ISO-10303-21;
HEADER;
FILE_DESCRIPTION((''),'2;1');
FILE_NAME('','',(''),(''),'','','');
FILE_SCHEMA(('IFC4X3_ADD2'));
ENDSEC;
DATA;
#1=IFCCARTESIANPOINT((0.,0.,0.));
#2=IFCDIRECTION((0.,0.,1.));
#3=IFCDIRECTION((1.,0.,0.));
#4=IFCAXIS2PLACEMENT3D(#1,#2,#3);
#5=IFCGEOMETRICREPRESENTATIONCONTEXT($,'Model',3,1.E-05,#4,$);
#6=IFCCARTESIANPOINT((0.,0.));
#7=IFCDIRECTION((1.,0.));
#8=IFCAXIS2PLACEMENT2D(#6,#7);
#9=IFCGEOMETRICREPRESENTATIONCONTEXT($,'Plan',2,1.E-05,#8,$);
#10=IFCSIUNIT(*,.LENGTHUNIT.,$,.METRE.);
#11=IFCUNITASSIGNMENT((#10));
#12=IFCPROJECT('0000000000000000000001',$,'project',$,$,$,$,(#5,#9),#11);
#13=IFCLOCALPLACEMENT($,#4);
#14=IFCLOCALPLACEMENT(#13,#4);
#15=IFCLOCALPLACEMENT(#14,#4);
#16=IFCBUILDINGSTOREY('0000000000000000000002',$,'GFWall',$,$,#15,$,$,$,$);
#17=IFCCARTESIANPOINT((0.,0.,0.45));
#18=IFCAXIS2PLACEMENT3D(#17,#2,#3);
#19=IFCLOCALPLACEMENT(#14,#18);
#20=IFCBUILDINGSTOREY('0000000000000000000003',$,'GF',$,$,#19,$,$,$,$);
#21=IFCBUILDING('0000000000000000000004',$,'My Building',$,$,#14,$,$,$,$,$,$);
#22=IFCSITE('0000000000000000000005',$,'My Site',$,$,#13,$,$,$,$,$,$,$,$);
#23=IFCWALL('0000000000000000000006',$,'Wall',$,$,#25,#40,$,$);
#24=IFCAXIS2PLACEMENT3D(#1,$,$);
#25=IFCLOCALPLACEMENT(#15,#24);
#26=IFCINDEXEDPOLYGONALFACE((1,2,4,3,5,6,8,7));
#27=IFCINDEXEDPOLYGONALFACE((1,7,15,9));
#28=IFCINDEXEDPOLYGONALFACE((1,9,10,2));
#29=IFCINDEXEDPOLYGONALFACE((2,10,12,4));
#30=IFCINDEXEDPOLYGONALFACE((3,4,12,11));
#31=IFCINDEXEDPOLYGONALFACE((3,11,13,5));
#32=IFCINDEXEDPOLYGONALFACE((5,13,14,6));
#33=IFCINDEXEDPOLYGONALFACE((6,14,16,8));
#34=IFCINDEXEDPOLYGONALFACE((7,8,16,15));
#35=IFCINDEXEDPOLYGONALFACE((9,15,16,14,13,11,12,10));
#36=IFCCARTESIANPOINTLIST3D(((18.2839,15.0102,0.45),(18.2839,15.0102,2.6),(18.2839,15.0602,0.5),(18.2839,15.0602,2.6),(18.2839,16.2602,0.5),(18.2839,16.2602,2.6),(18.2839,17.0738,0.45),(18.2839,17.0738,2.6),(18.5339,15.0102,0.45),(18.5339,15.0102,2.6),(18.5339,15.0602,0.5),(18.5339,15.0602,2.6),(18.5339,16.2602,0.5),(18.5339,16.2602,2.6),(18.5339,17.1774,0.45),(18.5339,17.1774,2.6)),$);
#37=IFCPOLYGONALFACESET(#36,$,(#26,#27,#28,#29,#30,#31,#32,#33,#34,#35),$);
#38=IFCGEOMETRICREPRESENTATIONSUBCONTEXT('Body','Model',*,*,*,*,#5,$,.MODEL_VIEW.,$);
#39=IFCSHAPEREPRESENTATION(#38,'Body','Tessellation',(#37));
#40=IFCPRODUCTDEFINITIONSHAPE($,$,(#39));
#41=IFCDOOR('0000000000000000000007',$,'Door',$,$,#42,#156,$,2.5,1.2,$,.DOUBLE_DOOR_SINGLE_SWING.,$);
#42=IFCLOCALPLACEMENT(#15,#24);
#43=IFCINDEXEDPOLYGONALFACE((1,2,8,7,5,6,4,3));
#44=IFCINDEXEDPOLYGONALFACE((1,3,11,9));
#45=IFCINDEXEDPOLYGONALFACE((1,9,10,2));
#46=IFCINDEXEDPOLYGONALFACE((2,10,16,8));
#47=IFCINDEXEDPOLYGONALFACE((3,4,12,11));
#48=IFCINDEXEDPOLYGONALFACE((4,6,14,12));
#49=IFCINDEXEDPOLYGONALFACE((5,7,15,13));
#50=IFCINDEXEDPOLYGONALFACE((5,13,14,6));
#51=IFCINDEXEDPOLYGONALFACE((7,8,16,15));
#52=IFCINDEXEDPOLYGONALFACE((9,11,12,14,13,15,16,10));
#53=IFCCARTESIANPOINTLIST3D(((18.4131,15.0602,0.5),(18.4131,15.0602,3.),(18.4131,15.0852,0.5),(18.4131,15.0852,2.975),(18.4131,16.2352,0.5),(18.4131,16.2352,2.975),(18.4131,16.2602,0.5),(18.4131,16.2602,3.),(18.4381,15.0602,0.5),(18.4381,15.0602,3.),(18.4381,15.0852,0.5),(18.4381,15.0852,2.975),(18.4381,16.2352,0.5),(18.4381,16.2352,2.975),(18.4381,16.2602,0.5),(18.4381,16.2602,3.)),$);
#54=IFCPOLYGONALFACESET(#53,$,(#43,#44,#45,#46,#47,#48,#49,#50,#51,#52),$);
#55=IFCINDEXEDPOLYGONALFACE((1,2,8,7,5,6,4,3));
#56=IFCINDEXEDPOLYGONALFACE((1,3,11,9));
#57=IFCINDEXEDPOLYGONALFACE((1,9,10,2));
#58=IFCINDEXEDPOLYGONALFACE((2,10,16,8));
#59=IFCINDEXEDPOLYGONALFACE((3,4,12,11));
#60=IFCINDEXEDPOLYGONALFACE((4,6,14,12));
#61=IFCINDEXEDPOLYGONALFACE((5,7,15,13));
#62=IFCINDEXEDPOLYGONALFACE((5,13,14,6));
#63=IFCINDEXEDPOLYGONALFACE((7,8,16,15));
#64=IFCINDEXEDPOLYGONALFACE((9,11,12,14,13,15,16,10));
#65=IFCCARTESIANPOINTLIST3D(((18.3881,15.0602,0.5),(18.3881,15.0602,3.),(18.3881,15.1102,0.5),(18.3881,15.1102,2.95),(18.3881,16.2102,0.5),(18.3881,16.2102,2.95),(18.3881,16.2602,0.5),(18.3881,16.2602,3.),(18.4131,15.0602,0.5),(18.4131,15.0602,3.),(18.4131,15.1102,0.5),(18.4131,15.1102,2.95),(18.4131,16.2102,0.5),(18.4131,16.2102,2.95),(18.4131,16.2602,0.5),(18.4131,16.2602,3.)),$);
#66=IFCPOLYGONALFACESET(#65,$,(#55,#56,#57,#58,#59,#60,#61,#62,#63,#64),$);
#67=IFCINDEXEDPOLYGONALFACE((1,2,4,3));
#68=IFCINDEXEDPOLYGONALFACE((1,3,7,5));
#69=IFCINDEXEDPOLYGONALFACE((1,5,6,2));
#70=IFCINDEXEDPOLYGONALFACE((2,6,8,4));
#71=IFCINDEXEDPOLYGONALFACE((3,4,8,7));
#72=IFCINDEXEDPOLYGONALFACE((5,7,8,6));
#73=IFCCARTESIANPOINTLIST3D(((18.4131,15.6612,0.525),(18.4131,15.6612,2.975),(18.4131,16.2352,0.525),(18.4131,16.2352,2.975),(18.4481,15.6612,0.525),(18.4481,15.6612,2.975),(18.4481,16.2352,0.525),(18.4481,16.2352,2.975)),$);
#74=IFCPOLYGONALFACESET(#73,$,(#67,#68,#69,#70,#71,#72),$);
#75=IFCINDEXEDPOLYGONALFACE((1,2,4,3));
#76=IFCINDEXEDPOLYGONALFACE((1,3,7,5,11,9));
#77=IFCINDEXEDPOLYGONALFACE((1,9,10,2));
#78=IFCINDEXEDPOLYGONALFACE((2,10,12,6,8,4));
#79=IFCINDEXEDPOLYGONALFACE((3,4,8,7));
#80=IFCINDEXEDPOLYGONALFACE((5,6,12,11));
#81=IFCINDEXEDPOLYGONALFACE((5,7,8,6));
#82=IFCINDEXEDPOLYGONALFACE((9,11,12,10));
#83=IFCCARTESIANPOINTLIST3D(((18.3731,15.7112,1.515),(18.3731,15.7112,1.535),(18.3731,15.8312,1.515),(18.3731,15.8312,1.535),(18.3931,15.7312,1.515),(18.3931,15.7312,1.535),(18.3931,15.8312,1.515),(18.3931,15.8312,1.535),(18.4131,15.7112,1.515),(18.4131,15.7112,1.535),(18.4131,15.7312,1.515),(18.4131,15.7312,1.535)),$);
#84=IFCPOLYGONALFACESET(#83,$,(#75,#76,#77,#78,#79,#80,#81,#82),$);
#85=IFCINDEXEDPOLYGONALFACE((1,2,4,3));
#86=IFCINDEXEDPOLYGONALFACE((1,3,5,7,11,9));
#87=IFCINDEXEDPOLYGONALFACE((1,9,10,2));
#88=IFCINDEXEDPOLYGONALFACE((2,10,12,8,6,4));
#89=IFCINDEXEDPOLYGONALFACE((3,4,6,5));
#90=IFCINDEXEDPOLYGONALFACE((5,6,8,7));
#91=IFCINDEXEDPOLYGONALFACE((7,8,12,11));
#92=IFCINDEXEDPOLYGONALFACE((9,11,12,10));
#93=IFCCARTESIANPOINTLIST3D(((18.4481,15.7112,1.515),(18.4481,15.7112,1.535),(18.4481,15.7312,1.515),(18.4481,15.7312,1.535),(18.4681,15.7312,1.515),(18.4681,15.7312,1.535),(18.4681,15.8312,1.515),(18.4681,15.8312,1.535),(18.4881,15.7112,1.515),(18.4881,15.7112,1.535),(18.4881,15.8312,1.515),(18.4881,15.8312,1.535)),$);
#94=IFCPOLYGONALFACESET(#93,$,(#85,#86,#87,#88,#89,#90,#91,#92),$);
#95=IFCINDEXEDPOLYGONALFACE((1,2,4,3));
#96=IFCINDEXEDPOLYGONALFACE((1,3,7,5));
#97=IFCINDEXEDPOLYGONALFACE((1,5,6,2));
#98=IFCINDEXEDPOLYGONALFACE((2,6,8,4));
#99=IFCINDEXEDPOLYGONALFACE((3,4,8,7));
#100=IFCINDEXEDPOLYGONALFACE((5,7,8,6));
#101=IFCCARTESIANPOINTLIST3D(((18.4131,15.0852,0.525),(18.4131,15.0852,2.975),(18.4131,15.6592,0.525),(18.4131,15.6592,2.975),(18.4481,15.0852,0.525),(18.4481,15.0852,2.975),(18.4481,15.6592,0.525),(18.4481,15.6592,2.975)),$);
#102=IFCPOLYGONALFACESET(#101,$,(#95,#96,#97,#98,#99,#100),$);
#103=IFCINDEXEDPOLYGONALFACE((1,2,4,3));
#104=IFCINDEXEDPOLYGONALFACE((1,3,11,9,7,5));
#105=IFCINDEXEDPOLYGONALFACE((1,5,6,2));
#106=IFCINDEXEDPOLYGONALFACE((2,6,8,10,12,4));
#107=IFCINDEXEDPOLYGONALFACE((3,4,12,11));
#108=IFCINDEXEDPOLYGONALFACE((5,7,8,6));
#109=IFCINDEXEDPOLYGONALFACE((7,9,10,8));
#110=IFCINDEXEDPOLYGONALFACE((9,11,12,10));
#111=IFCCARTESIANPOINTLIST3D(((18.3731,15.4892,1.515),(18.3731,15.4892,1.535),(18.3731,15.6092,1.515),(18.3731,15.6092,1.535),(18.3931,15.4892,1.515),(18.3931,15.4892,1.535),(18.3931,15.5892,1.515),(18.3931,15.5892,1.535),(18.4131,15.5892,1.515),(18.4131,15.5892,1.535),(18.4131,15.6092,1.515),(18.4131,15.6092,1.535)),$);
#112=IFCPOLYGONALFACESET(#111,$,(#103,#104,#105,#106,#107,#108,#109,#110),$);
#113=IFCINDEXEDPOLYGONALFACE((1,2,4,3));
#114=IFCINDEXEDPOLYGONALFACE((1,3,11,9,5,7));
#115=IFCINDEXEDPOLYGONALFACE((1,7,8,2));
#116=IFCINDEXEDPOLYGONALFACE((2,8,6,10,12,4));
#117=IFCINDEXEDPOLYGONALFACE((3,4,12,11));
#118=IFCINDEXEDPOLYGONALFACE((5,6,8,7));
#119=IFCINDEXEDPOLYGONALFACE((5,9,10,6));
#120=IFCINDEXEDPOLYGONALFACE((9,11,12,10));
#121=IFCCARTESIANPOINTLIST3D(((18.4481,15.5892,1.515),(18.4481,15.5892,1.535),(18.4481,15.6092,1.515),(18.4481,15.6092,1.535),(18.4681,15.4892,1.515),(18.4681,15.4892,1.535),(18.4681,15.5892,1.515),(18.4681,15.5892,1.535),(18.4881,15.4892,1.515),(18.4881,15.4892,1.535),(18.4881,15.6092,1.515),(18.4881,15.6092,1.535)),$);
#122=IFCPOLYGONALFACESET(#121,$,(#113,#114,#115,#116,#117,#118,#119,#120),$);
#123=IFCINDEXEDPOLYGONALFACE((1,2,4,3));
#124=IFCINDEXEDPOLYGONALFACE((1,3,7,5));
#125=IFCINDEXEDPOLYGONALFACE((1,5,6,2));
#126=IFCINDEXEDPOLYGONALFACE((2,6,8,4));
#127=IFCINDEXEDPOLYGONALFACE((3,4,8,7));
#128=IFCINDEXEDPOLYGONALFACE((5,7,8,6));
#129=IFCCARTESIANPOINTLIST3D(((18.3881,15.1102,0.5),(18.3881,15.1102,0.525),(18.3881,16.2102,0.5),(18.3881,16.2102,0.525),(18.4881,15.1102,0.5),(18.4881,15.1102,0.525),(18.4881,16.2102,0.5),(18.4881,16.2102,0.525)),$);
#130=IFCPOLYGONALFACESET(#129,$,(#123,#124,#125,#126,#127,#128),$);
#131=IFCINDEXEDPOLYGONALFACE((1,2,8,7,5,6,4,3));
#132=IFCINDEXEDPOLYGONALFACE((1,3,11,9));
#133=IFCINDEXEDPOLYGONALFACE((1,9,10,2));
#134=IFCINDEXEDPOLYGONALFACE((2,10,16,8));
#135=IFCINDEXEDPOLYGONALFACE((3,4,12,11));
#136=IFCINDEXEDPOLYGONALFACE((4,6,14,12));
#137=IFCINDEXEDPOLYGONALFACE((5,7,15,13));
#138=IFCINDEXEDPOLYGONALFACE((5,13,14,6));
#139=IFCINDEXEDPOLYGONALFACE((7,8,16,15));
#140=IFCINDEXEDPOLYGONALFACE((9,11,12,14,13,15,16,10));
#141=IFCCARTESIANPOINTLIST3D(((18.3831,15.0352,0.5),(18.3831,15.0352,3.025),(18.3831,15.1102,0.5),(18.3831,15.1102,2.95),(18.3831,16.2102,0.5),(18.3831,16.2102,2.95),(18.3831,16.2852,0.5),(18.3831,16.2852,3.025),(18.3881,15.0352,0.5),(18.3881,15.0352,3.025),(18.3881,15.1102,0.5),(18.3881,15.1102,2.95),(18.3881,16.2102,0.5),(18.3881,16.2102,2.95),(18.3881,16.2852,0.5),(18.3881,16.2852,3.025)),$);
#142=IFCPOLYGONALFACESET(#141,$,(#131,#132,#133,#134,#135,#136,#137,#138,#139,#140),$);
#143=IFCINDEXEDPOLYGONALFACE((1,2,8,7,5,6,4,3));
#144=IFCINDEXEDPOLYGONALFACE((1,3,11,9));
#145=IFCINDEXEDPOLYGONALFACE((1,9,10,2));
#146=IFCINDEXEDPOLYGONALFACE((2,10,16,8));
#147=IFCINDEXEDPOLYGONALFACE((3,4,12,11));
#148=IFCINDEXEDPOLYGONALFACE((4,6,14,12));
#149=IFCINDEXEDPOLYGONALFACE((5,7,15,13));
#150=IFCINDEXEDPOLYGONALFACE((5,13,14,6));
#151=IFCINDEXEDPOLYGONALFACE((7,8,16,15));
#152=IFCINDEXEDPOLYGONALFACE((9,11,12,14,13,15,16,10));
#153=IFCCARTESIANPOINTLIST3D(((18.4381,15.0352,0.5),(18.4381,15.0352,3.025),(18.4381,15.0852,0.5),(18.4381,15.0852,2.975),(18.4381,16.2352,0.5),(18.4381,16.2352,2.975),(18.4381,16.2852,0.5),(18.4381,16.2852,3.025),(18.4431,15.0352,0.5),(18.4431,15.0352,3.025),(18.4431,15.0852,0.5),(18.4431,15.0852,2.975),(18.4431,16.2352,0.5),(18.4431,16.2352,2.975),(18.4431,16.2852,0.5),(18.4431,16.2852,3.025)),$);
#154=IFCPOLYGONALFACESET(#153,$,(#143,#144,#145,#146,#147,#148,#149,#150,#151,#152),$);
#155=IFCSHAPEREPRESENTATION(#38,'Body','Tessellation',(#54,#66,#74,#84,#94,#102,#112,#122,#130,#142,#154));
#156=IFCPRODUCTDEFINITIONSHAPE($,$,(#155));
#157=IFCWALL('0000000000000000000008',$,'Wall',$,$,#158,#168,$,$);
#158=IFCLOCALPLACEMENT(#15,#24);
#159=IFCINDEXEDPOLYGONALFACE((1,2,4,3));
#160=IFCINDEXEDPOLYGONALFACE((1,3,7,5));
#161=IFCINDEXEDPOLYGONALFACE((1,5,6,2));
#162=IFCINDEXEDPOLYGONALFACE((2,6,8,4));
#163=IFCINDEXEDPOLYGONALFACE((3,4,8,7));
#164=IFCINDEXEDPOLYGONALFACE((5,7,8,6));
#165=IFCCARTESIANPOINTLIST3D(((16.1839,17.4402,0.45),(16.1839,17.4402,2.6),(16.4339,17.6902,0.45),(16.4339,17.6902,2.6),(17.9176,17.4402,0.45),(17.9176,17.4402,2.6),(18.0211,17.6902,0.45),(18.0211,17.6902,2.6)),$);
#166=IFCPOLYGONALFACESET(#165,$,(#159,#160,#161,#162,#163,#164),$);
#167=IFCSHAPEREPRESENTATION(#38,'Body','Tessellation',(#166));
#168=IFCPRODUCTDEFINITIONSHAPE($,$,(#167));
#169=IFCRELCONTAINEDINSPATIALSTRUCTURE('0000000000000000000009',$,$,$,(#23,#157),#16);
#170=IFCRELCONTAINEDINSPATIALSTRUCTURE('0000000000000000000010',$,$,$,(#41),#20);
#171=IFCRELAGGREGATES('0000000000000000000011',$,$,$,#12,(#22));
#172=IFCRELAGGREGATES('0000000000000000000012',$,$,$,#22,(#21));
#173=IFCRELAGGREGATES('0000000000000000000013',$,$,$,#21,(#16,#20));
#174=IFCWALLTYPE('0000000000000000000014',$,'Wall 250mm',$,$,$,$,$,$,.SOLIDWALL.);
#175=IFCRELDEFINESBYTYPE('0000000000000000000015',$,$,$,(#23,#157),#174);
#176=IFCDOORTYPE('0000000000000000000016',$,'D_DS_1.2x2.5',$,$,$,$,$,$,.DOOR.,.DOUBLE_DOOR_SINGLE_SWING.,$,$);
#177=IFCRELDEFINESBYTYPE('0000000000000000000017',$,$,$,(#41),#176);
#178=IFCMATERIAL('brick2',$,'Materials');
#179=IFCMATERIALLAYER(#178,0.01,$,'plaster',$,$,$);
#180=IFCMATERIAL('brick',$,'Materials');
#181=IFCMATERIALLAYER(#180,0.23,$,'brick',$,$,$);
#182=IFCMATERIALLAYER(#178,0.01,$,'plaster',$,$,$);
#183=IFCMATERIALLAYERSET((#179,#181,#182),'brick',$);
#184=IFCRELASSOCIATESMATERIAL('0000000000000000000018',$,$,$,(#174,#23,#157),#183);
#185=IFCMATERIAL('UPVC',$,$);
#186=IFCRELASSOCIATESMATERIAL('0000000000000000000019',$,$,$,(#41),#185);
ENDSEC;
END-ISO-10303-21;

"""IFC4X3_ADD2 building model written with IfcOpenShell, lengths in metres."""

from ifc_helpers import new_model, entity, si_unit, frame, origin_with_axes, origin_2d_with_axis, place, context, subcontext, project, spatial, line, indexed_curve, outline, extrude, shape, source, transform, mapped, material, layer, layer_set, layer_usage, type_object, type_shapes, element, fill, save


model = new_model("IFC4X3_ADD2")

# Units and contexts
model_context = context("Model", 3, precision=1e-05, world=origin_with_axes())
plan_context = context("Plan", 2, precision=1e-05, world=origin_2d_with_axis())
body_context_1 = subcontext(model_context, "Body", "Model", "MODEL_VIEW")
body_context_2 = subcontext(plan_context, "Body", "Plan", "PLAN_VIEW")
ifc_project = project(units=[si_unit("LENGTHUNIT", "METRE")], contexts=[model_context, plan_context])

# Site, building, storey
site_placement = place(None, origin_with_axes())
site = spatial("IfcSite", under=ifc_project, at=site_placement, Name="My Site")
building_placement = place(site_placement, origin_with_axes())
building = spatial("IfcBuilding", under=site, at=building_placement, Name="My Building")
storey_1_placement = place(building_placement, origin_with_axes())
storey_1 = spatial("IfcBuildingStorey", under=building, at=storey_1_placement, Name="GFWall")

# Shared definitions
ifc_material_1 = material(Name="brick2", Category="Materials")
ifc_layer_1 = layer(ifc_material_1, 0.01, Name="plaster")
ifc_material_2 = material(Name="brick", Category="Materials")
ifc_layer_2 = layer(ifc_material_2, 0.23, Name="brick")
ifc_layer_3 = layer(ifc_material_1, 0.01, Name="plaster")
ifc_layer_set_1 = layer_set([ifc_layer_1, ifc_layer_2, ifc_layer_3], Name="brick")
wall_type_1 = type_object("IfcWallType", Name="Wall 250mm", PredefinedType="SOLIDWALL", material=ifc_layer_set_1)

# Shared definitions
storey_2_placement = place(building_placement, frame((0.0, 0.0, 0.45), z_axis=(0.0, 0.0, 1.0), x_axis=(1.0, 0.0, 0.0)))
storey_2 = spatial("IfcBuildingStorey", under=building, at=storey_2_placement, Name="GF")

# Wall, opening, door
ifc_material_3 = material(Name="UPVC")
ifc_layer_usage_1 = layer_usage(ifc_layer_set_1, "AXIS2", "NEGATIVE", 0.0)
wall_1_placement = place(storey_1_placement, frame((18.2839, 15.0102, 0.45), z_axis=(0.0, 0.0, 1.0), x_axis=(0.000001, 1.0, 0.0)))
wall_1 = element("IfcWall", 1, at=wall_1_placement, inside=storey_1, type_object=wall_type_1, material=ifc_layer_usage_1, Name="Wall", context=body_context_1, shape_type="SweptSolid", body=[
    extrude(outline(indexed_curve([(0.0, -0.25), (0.0, 0.0), (2.0636, 0.0), (2.1672, -0.25)], segments=[line(1, 2, 3, 4, 1)])), origin_with_axes(), (0.0, 0.0, 1.0), 2.15),
])
shared_shape_1 = source(origin_with_axes(), body_context_1, "Body", "SweptSolid", [
    extrude(outline(indexed_curve([(0.0, 0.0), (1.2, 0.0), (1.2, 2.5), (0.0, 2.5)], segments=[line(1, 2, 3, 4, 1)])), frame((0.0, -0.6, 0.0), z_axis=(0.0, -1.0, 0.0), x_axis=(1.0, 0.0, 0.0)), (0.0, 0.0, -1.0), 1.2),
])
opening_1_placement = place(wall_1_placement, frame((1.25, -0.1042, 0.05), z_axis=(0.0, 0.0, 1.0), x_axis=(-1.0, 0.0, 0.0)))
opening_1 = element("IfcOpeningElement", 2, at=opening_1_placement, cuts=wall_1, PredefinedType="OPENING", context=body_context_1, shape_type="MappedRepresentation", body=[
    mapped(shared_shape_1, transform((0.0, 0.0, 0.0), x_axis=(1.0, 0.0, 0.0), y_axis=(0.0, 1.0, 0.0), z_axis=(0.0, 0.0, 1.0), scale=1.0)),
])
door_type_1 = type_object("IfcDoorType", Name="D_DS_1.2x2.5", OperationType="DOUBLE_DOOR_SINGLE_SWING", PredefinedType="DOOR")
shared_shape_2 = source(origin_with_axes(), body_context_1, "Body", "SweptSolid", [
    extrude(outline(indexed_curve([(0.0, 0.0), (0.0, 2.5), (1.2, 2.5), (1.2, 0.0), (1.175, 0.0), (1.175, 2.475), (0.025, 2.475), (0.025, 0.0)], segments=[line(1, 2, 3, 4, 5, 6, 7, 8, 1)])), frame((0.0, 0.025, 0.0), z_axis=(0.0, -1.0, 0.0), x_axis=(1.0, 0.0, 0.0)), (0.0, 0.0, -1.0), 0.025),
    extrude(outline(indexed_curve([(0.0, 0.0), (0.0, 2.5), (1.2, 2.5), (1.2, 0.0), (1.15, 0.0), (1.15, 2.45), (0.05, 2.45), (0.05, 0.0)], segments=[line(1, 2, 3, 4, 5, 6, 7, 8, 1)])), frame((0.0, 0.0, 0.0), z_axis=(0.0, -1.0, 0.0), x_axis=(1.0, 0.0, 0.0)), (0.0, 0.0, -1.0), 0.025),
    extrude(outline(indexed_curve([(0.0, 0.0), (0.574, 0.0), (0.574, 0.035), (0.0, 0.035)], segments=[line(1, 2, 3, 4, 1)])), frame((0.025, 0.025, 0.025), z_axis=(0.0, 0.0, 1.0), x_axis=(1.0, 0.0, 0.0)), (0.0, 0.0, 1.0), 2.45),
    extrude(outline(indexed_curve([(0.0, 0.0), (0.0, -0.04), (-0.12, -0.04), (-0.12, -0.02), (-0.02, -0.02), (-0.02, 0.0)], segments=[line(1, 2, 3, 4, 5, 6, 1)])), frame((0.549, 0.025, 1.015), z_axis=(0.0, 0.0, 1.0), x_axis=(1.0, 0.0, 0.0)), (0.0, 0.0, 1.0), 0.02),
    extrude(outline(indexed_curve([(0.0, 0.0), (0.0, 0.04), (-0.12, 0.04), (-0.12, 0.02), (-0.02, 0.02), (-0.02, 0.0)], segments=[line(1, 2, 3, 4, 5, 6, 1)])), frame((0.549, 0.06, 1.015), z_axis=(0.0, 0.0, 1.0), x_axis=(1.0, 0.0, 0.0)), (0.0, 0.0, 1.0), 0.02),
    extrude(outline(indexed_curve([(0.0, 0.0), (-0.574, 0.0), (-0.574, 0.035), (0.0, 0.035)], segments=[line(1, 2, 3, 4, 1)])), frame((1.175, 0.025, 0.025), z_axis=(0.0, 0.0, 1.0), x_axis=(1.0, 0.0, 0.0)), (0.0, 0.0, 1.0), 2.45),
    extrude(outline(indexed_curve([(0.0, 0.0), (0.0, -0.04), (0.12, -0.04), (0.12, -0.02), (0.02, -0.02), (0.02, 0.0)], segments=[line(1, 2, 3, 4, 5, 6, 1)])), frame((0.651, 0.025, 1.015), z_axis=(0.0, 0.0, 1.0), x_axis=(1.0, 0.0, 0.0)), (0.0, 0.0, 1.0), 0.02),
    extrude(outline(indexed_curve([(0.0, 0.0), (0.0, 0.04), (0.12, 0.04), (0.12, 0.02), (0.02, 0.02), (0.02, 0.0)], segments=[line(1, 2, 3, 4, 5, 6, 1)])), frame((0.651, 0.06, 1.015), z_axis=(0.0, 0.0, 1.0), x_axis=(1.0, 0.0, 0.0)), (0.0, 0.0, 1.0), 0.02),
    extrude(outline(indexed_curve([(0.0, 0.0), (1.1, 0.0), (1.1, 0.1), (0.0, 0.1)], segments=[line(1, 2, 3, 4, 1)])), frame((0.05, 0.0, 0.0), z_axis=(0.0, 0.0, 1.0), x_axis=(1.0, 0.0, 0.0)), (0.0, 0.0, 1.0), 0.025),
    extrude(outline(indexed_curve([(0.0, 0.0), (0.0, 2.525), (1.25, 2.525), (1.25, 0.0), (1.175, 0.0), (1.175, 2.45), (0.075, 2.45), (0.075, 0.0)], segments=[line(1, 2, 3, 4, 5, 6, 7, 8, 1)])), frame((-0.025, -0.005, 0.0), z_axis=(0.0, -1.0, 0.0), x_axis=(1.0, 0.0, 0.0)), (0.0, 0.0, -1.0), 0.005),
    extrude(outline(indexed_curve([(0.0, 0.0), (0.0, 2.525), (1.25, 2.525), (1.25, 0.0), (1.2, 0.0), (1.2, 2.475), (0.05, 2.475), (0.05, 0.0)], segments=[line(1, 2, 3, 4, 5, 6, 7, 8, 1)])), frame((-0.025, 0.05, 0.0), z_axis=(0.0, -1.0, 0.0), x_axis=(1.0, 0.0, 0.0)), (0.0, 0.0, -1.0), 0.005),
])
shared_shape_3 = source(origin_with_axes(), body_context_2, "Body", "Curve2D", [
    entity("IfcIndexedPolyCurve", entity("IfcCartesianPointList2D", [[0.0, 0.0], [0.0, 0.05], [0.025, 0.05], [0.025, 0.025], [0.05, 0.025], [0.05, 0.0]]), [entity("IfcLineIndex", [1, 2, 3, 4, 5, 6, 1])]),
    entity("IfcIndexedPolyCurve", entity("IfcCartesianPointList2D", [[1.2, 0.0], [1.2, 0.05], [1.175, 0.05], [1.175, 0.025], [1.15, 0.025], [1.15, 0.0]]), [entity("IfcLineIndex", [1, 2, 3, 4, 5, 6, 1])]),
    entity("IfcTrimmedCurve", entity("IfcEllipse", entity("IfcAxis2Placement2D", entity("IfcCartesianPoint", [0.06, 0.05]), entity("IfcDirection", [1.0, 0.0])), 0.54, 0.575), [entity("IfcCartesianPoint", [0.6, 0.05])], [entity("IfcCartesianPoint", [0.06, 0.625])], True, "CARTESIAN"),
    entity("IfcIndexedPolyCurve", entity("IfcCartesianPointList2D", [[0.025, 0.05], [0.06, 0.05], [0.06, 0.625], [0.025, 0.625]]), [entity("IfcLineIndex", [1, 2, 3, 4, 1])]),
    entity("IfcTrimmedCurve", entity("IfcEllipse", entity("IfcAxis2Placement2D", entity("IfcCartesianPoint", [1.14, 0.05]), entity("IfcDirection", [1.0, 0.0])), 0.54, 0.575), [entity("IfcCartesianPoint", [1.14, 0.625])], [entity("IfcCartesianPoint", [0.6, 0.05])], True, "CARTESIAN"),
    entity("IfcIndexedPolyCurve", entity("IfcCartesianPointList2D", [[1.175, 0.05], [1.14, 0.05], [1.14, 0.625], [1.175, 0.625]]), [entity("IfcLineIndex", [1, 2, 3, 4, 1])]),
])
type_shapes(door_type_1, [shared_shape_2, shared_shape_3])
door_1_placement = place(opening_1_placement, frame((0.0, 0.0, 0.0), z_axis=(0.0, 0.0, 1.0), x_axis=(1.0, 0.0, 0.0)))
door_1 = element("IfcDoor", 3, at=door_1_placement, inside=storey_2, type_object=door_type_1, material=ifc_material_3, Name="Door", OperationType="DOUBLE_DOOR_SINGLE_SWING", OverallHeight=2.5, OverallWidth=1.2, shapes=[
    shape(body_context_1, "Body", "MappedRepresentation", [mapped(shared_shape_2, transform((0.0, 0.0, 0.0), x_axis=(1.0, 0.0, 0.0), y_axis=(0.0, 1.0, 0.0), z_axis=(0.0, 0.0, 1.0), scale=1.0))]),
    shape(body_context_2, "Body", "MappedRepresentation", [mapped(shared_shape_3, transform((0.0, 0.0, 0.0), x_axis=(1.0, 0.0, 0.0), y_axis=(0.0, 1.0, 0.0), z_axis=(0.0, 0.0, 1.0), scale=1.0))]),
])
fill(opening_1, door_1)

# Wall
ifc_layer_usage_2 = layer_usage(ifc_layer_set_1, "AXIS2", "NEGATIVE", 0.0)
wall_2_placement = place(storey_1_placement, frame((17.9176, 17.4402, 0.45), z_axis=(0.0, 0.0, 1.0), x_axis=(-1.0, 0.0, 0.0)))
element("IfcWall", 4, at=wall_2_placement, inside=storey_1, type_object=wall_type_1, material=ifc_layer_usage_2, Name="Wall", context=body_context_1, shape_type="SweptSolid", body=[
    extrude(outline(indexed_curve([(-0.1036, -0.25), (0.0, 0.0), (1.7336, 0.0), (1.4836, -0.25)], segments=[line(1, 2, 3, 4, 1)])), origin_with_axes(), (0.0, 0.0, 1.0), 2.15),
])

save(model, "model.ifc")
